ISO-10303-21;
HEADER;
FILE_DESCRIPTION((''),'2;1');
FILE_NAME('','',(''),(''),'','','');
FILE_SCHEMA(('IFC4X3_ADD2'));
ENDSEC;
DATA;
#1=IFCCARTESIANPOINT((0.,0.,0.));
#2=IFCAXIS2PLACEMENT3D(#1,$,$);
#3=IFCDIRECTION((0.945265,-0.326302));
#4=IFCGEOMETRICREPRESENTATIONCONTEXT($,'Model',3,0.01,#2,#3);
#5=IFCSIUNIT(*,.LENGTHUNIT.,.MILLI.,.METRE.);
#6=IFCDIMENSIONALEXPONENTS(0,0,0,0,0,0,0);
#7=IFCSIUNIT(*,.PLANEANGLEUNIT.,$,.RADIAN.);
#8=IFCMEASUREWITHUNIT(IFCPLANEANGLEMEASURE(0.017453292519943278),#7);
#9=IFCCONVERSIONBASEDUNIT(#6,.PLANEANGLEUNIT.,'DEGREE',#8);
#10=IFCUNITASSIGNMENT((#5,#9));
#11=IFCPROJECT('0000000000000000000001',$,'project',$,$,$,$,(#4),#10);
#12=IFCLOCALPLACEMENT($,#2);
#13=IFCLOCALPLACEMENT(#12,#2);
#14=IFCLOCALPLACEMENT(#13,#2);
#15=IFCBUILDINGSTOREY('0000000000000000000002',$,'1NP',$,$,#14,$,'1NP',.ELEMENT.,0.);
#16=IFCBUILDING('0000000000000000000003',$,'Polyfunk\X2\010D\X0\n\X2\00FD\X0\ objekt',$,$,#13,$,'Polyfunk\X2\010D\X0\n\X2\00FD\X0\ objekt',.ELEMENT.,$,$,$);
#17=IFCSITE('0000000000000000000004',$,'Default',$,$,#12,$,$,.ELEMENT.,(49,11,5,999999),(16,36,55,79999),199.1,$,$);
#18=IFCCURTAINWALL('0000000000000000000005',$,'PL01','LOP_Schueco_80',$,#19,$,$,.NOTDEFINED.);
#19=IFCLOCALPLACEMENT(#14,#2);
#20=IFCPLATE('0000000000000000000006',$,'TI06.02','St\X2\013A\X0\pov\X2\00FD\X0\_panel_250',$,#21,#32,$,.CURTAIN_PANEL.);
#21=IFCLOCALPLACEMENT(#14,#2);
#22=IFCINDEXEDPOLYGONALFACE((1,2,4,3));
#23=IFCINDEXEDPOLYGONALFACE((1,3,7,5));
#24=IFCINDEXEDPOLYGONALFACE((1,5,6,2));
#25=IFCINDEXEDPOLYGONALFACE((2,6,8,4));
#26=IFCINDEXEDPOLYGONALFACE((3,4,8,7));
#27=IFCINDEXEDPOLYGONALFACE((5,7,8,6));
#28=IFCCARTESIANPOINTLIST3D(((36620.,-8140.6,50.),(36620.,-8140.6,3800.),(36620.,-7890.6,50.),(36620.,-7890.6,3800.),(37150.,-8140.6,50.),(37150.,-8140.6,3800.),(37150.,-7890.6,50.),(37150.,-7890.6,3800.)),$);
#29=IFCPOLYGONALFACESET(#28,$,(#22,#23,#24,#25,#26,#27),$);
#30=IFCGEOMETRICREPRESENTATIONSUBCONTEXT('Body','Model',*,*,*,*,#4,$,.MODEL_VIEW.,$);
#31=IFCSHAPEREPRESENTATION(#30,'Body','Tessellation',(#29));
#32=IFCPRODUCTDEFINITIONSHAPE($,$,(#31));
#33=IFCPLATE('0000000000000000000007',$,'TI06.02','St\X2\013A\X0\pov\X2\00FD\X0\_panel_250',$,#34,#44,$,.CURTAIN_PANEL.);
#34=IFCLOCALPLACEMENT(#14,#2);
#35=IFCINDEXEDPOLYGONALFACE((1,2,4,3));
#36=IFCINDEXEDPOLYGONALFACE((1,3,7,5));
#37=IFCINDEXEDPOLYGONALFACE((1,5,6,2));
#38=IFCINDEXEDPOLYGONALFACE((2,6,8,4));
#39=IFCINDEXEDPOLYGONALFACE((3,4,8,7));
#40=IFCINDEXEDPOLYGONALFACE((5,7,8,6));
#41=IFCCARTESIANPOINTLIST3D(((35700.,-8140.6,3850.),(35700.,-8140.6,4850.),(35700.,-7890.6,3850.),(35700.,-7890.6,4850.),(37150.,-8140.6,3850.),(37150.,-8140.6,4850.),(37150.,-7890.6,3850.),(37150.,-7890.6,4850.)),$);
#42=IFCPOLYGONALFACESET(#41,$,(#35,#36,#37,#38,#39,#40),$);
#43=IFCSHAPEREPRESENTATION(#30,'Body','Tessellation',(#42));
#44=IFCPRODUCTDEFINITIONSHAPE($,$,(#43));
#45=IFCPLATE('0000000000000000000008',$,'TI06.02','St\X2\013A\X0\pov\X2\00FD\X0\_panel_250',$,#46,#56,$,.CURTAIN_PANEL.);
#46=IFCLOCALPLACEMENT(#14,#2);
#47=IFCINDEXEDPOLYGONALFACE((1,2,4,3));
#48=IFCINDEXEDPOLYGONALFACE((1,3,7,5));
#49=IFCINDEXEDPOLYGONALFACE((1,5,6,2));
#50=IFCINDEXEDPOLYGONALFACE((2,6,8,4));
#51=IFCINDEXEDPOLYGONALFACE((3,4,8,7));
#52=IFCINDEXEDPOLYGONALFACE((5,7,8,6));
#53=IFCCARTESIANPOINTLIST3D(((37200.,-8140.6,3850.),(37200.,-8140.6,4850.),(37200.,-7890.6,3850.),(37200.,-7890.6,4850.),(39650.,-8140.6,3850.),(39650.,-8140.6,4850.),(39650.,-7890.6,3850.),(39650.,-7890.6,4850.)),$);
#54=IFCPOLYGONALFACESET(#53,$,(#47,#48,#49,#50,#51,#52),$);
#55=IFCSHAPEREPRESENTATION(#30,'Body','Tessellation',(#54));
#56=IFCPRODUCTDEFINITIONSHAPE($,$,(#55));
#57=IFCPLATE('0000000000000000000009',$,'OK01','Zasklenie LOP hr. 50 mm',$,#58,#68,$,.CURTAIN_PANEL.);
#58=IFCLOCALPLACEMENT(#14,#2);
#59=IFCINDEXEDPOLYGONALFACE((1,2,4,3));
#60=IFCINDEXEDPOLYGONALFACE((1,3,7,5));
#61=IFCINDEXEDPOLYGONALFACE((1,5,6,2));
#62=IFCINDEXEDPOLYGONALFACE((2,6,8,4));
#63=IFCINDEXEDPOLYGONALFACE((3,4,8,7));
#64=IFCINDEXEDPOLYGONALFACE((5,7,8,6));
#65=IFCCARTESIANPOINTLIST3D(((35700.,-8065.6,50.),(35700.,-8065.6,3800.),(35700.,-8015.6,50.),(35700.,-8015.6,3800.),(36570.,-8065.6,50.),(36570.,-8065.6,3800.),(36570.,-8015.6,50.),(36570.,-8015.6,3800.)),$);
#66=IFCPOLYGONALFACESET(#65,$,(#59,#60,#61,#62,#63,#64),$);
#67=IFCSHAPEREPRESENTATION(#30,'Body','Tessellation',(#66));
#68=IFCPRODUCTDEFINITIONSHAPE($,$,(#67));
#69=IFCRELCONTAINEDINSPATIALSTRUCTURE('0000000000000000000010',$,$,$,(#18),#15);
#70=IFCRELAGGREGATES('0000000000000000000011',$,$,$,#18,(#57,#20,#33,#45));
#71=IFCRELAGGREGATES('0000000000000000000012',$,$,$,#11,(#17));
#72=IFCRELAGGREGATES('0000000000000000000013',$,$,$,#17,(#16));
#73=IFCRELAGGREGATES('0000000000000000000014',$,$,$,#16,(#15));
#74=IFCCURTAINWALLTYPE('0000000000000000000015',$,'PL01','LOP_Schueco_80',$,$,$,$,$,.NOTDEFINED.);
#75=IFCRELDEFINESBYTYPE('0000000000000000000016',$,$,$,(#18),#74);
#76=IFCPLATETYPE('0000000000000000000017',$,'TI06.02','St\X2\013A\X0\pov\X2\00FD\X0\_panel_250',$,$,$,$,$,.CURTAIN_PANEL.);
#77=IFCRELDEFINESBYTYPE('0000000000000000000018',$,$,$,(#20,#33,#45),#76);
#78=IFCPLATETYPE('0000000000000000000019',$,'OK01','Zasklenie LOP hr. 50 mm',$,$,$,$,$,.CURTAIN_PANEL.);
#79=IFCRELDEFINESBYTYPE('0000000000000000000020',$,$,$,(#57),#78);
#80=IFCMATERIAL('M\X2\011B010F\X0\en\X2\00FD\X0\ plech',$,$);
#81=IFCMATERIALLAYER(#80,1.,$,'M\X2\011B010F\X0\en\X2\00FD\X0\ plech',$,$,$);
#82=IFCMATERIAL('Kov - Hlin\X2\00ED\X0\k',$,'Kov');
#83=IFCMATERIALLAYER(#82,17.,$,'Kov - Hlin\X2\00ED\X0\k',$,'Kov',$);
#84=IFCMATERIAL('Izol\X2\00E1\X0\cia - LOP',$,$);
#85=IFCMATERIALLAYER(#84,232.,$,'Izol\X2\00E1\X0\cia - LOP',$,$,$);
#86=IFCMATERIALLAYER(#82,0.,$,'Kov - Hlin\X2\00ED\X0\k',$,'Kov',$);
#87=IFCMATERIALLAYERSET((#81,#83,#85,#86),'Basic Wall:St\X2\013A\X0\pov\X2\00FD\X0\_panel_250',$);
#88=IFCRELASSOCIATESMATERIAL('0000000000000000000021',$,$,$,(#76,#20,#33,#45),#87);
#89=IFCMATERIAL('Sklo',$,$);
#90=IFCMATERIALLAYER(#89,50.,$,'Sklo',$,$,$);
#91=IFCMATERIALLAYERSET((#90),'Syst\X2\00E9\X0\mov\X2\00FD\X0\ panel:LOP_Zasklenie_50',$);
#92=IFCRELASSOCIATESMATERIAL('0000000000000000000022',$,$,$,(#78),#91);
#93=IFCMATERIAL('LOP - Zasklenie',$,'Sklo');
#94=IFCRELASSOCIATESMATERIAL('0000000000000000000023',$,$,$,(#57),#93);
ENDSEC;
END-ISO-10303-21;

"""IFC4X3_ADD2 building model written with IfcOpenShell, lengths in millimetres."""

from ifc_helpers import new_model, entity, si_unit, converted_unit, direction, frame, frame_2d, origin, place, context, subcontext, project, spatial, rectangle, extrude, source, transform, mapped, material, layer, layer_set, layer_usage, type_object, type_shapes, element, aggregate, save


model = new_model("IFC4X3_ADD2")

# Units and contexts
model_context = context("Model", 3, precision=0.01, world=origin(), true_north=direction((0.945265, -0.326302)))
body_context = subcontext(model_context, "Body", "Model", "MODEL_VIEW")
ifc_project = project(units=[si_unit("LENGTHUNIT", "METRE", prefix="MILLI"), converted_unit("PLANEANGLEUNIT", "DEGREE", entity("IfcPlaneAngleMeasure", 0.017453292519943278), si_unit("PLANEANGLEUNIT", "RADIAN"), dimensions=[0, 0, 0, 0, 0, 0, 0])], contexts=[model_context])

# Site, building, storey
site_placement = place(None, origin())
site = spatial("IfcSite", under=ifc_project, at=site_placement, Name="Default", CompositionType="ELEMENT", RefLatitude=(49, 11, 5, 999999), RefLongitude=(16, 36, 55, 79999), RefElevation=199.1)
building_placement = place(site_placement, origin())
building = spatial("IfcBuilding", under=site, at=building_placement, Name="Polyfunkčný objekt", LongName="Polyfunkčný objekt", CompositionType="ELEMENT")
storey_placement = place(building_placement, origin())
storey = spatial("IfcBuildingStorey", under=building, at=storey_placement, Name="1NP", LongName="1NP", CompositionType="ELEMENT", Elevation=0.0)

# Curtain wall, plates
curtain_wall_type = type_object("IfcCurtainWallType", Name="PL01", Description="LOP_Schueco_80", PredefinedType="NOTDEFINED")
curtain_wall_placement = place(storey_placement, origin())
curtain_wall = element("IfcCurtainWall", 1, at=curtain_wall_placement, inside=storey, type_object=curtain_wall_type, Name="PL01", Description="LOP_Schueco_80", PredefinedType="NOTDEFINED")
ifc_material_1 = material(Name="Měďený plech")
ifc_layer_1 = layer(ifc_material_1, 1.0, Name="Měďený plech")
ifc_material_2 = material(Name="Kov - Hliník", Category="Kov")
ifc_layer_2 = layer(ifc_material_2, 17.0, Name="Kov - Hliník", Category="Kov")
ifc_material_3 = material(Name="Izolácia - LOP")
ifc_layer_3 = layer(ifc_material_3, 232.0, Name="Izolácia - LOP")
ifc_layer_4 = layer(ifc_material_2, 0.0, Name="Kov - Hliník", Category="Kov")
ifc_layer_set_1 = layer_set([ifc_layer_1, ifc_layer_2, ifc_layer_3, ifc_layer_4], Name="Basic Wall:Stĺpový_panel_250")
ifc_layer_usage_1 = layer_usage(ifc_layer_set_1, "AXIS2", "POSITIVE", -125.0)
plate_type_1 = type_object("IfcPlateType", Name="TI06.02", Description="Stĺpový_panel_250", PredefinedType="CURTAIN_PANEL", material=ifc_layer_set_1)
plate_1_placement = place(storey_placement, frame((36620.0, -8015.6, 50.0)))
plate_1 = element("IfcPlate", 2, at=plate_1_placement, type_object=plate_type_1, material=ifc_layer_usage_1, Name="TI06.02", Description="Stĺpový_panel_250", PredefinedType="CURTAIN_PANEL", context=body_context, shape_type="SweptSolid", body=[
    extrude(rectangle(XDim=250.0, YDim=530.0, at=frame_2d((0.0, 0.0), x_axis=(1.0, 0.0))), frame((265.0, 0.0, 0.0), z_axis=(0.0, 0.0, 1.0), x_axis=(0.0, 1.0, 0.0)), (0.0, 0.0, 1.0), 3750.0),
])
ifc_layer_usage_2 = layer_usage(ifc_layer_set_1, "AXIS2", "POSITIVE", -125.0)
plate_2_placement = place(storey_placement, frame((35700.0, -8015.6, 3850.0)))
plate_2 = element("IfcPlate", 3, at=plate_2_placement, type_object=plate_type_1, material=ifc_layer_usage_2, Name="TI06.02", Description="Stĺpový_panel_250", PredefinedType="CURTAIN_PANEL", context=body_context, shape_type="SweptSolid", body=[
    extrude(rectangle(XDim=250.0, YDim=1450.0, at=frame_2d((0.0, 0.0), x_axis=(1.0, 0.0))), frame((725.0, 0.0, 0.0), z_axis=(0.0, 0.0, 1.0), x_axis=(0.0, 1.0, 0.0)), (0.0, 0.0, 1.0), 1000.0),
])
ifc_layer_usage_3 = layer_usage(ifc_layer_set_1, "AXIS2", "POSITIVE", -125.0)
plate_3_placement = place(storey_placement, frame((37200.0, -8015.6, 3850.0)))
plate_3 = element("IfcPlate", 4, at=plate_3_placement, type_object=plate_type_1, material=ifc_layer_usage_3, Name="TI06.02", Description="Stĺpový_panel_250", PredefinedType="CURTAIN_PANEL", context=body_context, shape_type="SweptSolid", body=[
    extrude(rectangle(XDim=250.0, YDim=2450.0, at=frame_2d((0.0, 0.0), x_axis=(1.0, 0.0))), frame((1225.0, 0.0, 0.0), z_axis=(0.0, 0.0, 1.0), x_axis=(0.0, 1.0, 0.0)), (0.0, 0.0, 1.0), 1000.0),
])
ifc_material_4 = material(Name="LOP - Zasklenie", Category="Sklo")
ifc_material_5 = material(Name="Sklo")
ifc_layer_5 = layer(ifc_material_5, 50.0, Name="Sklo")
ifc_layer_set_2 = layer_set([ifc_layer_5], Name="Systémový panel:LOP_Zasklenie_50")
plate_type_2 = type_object("IfcPlateType", Name="OK01", Description="Zasklenie LOP hr. 50 mm", PredefinedType="CURTAIN_PANEL", material=ifc_layer_set_2)
shared_shape_1 = source(origin(), body_context, "Body", "SweptSolid", [
    extrude(rectangle(XDim=3750.0, YDim=870.0, at=frame_2d((-331.2, 0.0), x_axis=(1.0, 0.0))), frame((0.0, -50.0, 2206.2), z_axis=(0.0, 1.0, 0.0), x_axis=(0.0, 0.0, 1.0)), (0.0, 0.0, 1.0), 50.0),
])
type_shapes(plate_type_2, [shared_shape_1])
plate_4_placement = place(curtain_wall_placement, frame((36135.0, -8015.6, 50.0)))
plate_4 = element("IfcPlate", 5, at=plate_4_placement, type_object=plate_type_2, material=ifc_material_4, Name="OK01", Description="Zasklenie LOP hr. 50 mm", PredefinedType="CURTAIN_PANEL", context=body_context, shape_type="MappedRepresentation", body=[
    mapped(shared_shape_1, transform((0.0, 0.0, 0.0), scale=1.0)),
])
aggregate(curtain_wall, [plate_4, plate_1, plate_2, plate_3])

save(model, "model.ifc")
